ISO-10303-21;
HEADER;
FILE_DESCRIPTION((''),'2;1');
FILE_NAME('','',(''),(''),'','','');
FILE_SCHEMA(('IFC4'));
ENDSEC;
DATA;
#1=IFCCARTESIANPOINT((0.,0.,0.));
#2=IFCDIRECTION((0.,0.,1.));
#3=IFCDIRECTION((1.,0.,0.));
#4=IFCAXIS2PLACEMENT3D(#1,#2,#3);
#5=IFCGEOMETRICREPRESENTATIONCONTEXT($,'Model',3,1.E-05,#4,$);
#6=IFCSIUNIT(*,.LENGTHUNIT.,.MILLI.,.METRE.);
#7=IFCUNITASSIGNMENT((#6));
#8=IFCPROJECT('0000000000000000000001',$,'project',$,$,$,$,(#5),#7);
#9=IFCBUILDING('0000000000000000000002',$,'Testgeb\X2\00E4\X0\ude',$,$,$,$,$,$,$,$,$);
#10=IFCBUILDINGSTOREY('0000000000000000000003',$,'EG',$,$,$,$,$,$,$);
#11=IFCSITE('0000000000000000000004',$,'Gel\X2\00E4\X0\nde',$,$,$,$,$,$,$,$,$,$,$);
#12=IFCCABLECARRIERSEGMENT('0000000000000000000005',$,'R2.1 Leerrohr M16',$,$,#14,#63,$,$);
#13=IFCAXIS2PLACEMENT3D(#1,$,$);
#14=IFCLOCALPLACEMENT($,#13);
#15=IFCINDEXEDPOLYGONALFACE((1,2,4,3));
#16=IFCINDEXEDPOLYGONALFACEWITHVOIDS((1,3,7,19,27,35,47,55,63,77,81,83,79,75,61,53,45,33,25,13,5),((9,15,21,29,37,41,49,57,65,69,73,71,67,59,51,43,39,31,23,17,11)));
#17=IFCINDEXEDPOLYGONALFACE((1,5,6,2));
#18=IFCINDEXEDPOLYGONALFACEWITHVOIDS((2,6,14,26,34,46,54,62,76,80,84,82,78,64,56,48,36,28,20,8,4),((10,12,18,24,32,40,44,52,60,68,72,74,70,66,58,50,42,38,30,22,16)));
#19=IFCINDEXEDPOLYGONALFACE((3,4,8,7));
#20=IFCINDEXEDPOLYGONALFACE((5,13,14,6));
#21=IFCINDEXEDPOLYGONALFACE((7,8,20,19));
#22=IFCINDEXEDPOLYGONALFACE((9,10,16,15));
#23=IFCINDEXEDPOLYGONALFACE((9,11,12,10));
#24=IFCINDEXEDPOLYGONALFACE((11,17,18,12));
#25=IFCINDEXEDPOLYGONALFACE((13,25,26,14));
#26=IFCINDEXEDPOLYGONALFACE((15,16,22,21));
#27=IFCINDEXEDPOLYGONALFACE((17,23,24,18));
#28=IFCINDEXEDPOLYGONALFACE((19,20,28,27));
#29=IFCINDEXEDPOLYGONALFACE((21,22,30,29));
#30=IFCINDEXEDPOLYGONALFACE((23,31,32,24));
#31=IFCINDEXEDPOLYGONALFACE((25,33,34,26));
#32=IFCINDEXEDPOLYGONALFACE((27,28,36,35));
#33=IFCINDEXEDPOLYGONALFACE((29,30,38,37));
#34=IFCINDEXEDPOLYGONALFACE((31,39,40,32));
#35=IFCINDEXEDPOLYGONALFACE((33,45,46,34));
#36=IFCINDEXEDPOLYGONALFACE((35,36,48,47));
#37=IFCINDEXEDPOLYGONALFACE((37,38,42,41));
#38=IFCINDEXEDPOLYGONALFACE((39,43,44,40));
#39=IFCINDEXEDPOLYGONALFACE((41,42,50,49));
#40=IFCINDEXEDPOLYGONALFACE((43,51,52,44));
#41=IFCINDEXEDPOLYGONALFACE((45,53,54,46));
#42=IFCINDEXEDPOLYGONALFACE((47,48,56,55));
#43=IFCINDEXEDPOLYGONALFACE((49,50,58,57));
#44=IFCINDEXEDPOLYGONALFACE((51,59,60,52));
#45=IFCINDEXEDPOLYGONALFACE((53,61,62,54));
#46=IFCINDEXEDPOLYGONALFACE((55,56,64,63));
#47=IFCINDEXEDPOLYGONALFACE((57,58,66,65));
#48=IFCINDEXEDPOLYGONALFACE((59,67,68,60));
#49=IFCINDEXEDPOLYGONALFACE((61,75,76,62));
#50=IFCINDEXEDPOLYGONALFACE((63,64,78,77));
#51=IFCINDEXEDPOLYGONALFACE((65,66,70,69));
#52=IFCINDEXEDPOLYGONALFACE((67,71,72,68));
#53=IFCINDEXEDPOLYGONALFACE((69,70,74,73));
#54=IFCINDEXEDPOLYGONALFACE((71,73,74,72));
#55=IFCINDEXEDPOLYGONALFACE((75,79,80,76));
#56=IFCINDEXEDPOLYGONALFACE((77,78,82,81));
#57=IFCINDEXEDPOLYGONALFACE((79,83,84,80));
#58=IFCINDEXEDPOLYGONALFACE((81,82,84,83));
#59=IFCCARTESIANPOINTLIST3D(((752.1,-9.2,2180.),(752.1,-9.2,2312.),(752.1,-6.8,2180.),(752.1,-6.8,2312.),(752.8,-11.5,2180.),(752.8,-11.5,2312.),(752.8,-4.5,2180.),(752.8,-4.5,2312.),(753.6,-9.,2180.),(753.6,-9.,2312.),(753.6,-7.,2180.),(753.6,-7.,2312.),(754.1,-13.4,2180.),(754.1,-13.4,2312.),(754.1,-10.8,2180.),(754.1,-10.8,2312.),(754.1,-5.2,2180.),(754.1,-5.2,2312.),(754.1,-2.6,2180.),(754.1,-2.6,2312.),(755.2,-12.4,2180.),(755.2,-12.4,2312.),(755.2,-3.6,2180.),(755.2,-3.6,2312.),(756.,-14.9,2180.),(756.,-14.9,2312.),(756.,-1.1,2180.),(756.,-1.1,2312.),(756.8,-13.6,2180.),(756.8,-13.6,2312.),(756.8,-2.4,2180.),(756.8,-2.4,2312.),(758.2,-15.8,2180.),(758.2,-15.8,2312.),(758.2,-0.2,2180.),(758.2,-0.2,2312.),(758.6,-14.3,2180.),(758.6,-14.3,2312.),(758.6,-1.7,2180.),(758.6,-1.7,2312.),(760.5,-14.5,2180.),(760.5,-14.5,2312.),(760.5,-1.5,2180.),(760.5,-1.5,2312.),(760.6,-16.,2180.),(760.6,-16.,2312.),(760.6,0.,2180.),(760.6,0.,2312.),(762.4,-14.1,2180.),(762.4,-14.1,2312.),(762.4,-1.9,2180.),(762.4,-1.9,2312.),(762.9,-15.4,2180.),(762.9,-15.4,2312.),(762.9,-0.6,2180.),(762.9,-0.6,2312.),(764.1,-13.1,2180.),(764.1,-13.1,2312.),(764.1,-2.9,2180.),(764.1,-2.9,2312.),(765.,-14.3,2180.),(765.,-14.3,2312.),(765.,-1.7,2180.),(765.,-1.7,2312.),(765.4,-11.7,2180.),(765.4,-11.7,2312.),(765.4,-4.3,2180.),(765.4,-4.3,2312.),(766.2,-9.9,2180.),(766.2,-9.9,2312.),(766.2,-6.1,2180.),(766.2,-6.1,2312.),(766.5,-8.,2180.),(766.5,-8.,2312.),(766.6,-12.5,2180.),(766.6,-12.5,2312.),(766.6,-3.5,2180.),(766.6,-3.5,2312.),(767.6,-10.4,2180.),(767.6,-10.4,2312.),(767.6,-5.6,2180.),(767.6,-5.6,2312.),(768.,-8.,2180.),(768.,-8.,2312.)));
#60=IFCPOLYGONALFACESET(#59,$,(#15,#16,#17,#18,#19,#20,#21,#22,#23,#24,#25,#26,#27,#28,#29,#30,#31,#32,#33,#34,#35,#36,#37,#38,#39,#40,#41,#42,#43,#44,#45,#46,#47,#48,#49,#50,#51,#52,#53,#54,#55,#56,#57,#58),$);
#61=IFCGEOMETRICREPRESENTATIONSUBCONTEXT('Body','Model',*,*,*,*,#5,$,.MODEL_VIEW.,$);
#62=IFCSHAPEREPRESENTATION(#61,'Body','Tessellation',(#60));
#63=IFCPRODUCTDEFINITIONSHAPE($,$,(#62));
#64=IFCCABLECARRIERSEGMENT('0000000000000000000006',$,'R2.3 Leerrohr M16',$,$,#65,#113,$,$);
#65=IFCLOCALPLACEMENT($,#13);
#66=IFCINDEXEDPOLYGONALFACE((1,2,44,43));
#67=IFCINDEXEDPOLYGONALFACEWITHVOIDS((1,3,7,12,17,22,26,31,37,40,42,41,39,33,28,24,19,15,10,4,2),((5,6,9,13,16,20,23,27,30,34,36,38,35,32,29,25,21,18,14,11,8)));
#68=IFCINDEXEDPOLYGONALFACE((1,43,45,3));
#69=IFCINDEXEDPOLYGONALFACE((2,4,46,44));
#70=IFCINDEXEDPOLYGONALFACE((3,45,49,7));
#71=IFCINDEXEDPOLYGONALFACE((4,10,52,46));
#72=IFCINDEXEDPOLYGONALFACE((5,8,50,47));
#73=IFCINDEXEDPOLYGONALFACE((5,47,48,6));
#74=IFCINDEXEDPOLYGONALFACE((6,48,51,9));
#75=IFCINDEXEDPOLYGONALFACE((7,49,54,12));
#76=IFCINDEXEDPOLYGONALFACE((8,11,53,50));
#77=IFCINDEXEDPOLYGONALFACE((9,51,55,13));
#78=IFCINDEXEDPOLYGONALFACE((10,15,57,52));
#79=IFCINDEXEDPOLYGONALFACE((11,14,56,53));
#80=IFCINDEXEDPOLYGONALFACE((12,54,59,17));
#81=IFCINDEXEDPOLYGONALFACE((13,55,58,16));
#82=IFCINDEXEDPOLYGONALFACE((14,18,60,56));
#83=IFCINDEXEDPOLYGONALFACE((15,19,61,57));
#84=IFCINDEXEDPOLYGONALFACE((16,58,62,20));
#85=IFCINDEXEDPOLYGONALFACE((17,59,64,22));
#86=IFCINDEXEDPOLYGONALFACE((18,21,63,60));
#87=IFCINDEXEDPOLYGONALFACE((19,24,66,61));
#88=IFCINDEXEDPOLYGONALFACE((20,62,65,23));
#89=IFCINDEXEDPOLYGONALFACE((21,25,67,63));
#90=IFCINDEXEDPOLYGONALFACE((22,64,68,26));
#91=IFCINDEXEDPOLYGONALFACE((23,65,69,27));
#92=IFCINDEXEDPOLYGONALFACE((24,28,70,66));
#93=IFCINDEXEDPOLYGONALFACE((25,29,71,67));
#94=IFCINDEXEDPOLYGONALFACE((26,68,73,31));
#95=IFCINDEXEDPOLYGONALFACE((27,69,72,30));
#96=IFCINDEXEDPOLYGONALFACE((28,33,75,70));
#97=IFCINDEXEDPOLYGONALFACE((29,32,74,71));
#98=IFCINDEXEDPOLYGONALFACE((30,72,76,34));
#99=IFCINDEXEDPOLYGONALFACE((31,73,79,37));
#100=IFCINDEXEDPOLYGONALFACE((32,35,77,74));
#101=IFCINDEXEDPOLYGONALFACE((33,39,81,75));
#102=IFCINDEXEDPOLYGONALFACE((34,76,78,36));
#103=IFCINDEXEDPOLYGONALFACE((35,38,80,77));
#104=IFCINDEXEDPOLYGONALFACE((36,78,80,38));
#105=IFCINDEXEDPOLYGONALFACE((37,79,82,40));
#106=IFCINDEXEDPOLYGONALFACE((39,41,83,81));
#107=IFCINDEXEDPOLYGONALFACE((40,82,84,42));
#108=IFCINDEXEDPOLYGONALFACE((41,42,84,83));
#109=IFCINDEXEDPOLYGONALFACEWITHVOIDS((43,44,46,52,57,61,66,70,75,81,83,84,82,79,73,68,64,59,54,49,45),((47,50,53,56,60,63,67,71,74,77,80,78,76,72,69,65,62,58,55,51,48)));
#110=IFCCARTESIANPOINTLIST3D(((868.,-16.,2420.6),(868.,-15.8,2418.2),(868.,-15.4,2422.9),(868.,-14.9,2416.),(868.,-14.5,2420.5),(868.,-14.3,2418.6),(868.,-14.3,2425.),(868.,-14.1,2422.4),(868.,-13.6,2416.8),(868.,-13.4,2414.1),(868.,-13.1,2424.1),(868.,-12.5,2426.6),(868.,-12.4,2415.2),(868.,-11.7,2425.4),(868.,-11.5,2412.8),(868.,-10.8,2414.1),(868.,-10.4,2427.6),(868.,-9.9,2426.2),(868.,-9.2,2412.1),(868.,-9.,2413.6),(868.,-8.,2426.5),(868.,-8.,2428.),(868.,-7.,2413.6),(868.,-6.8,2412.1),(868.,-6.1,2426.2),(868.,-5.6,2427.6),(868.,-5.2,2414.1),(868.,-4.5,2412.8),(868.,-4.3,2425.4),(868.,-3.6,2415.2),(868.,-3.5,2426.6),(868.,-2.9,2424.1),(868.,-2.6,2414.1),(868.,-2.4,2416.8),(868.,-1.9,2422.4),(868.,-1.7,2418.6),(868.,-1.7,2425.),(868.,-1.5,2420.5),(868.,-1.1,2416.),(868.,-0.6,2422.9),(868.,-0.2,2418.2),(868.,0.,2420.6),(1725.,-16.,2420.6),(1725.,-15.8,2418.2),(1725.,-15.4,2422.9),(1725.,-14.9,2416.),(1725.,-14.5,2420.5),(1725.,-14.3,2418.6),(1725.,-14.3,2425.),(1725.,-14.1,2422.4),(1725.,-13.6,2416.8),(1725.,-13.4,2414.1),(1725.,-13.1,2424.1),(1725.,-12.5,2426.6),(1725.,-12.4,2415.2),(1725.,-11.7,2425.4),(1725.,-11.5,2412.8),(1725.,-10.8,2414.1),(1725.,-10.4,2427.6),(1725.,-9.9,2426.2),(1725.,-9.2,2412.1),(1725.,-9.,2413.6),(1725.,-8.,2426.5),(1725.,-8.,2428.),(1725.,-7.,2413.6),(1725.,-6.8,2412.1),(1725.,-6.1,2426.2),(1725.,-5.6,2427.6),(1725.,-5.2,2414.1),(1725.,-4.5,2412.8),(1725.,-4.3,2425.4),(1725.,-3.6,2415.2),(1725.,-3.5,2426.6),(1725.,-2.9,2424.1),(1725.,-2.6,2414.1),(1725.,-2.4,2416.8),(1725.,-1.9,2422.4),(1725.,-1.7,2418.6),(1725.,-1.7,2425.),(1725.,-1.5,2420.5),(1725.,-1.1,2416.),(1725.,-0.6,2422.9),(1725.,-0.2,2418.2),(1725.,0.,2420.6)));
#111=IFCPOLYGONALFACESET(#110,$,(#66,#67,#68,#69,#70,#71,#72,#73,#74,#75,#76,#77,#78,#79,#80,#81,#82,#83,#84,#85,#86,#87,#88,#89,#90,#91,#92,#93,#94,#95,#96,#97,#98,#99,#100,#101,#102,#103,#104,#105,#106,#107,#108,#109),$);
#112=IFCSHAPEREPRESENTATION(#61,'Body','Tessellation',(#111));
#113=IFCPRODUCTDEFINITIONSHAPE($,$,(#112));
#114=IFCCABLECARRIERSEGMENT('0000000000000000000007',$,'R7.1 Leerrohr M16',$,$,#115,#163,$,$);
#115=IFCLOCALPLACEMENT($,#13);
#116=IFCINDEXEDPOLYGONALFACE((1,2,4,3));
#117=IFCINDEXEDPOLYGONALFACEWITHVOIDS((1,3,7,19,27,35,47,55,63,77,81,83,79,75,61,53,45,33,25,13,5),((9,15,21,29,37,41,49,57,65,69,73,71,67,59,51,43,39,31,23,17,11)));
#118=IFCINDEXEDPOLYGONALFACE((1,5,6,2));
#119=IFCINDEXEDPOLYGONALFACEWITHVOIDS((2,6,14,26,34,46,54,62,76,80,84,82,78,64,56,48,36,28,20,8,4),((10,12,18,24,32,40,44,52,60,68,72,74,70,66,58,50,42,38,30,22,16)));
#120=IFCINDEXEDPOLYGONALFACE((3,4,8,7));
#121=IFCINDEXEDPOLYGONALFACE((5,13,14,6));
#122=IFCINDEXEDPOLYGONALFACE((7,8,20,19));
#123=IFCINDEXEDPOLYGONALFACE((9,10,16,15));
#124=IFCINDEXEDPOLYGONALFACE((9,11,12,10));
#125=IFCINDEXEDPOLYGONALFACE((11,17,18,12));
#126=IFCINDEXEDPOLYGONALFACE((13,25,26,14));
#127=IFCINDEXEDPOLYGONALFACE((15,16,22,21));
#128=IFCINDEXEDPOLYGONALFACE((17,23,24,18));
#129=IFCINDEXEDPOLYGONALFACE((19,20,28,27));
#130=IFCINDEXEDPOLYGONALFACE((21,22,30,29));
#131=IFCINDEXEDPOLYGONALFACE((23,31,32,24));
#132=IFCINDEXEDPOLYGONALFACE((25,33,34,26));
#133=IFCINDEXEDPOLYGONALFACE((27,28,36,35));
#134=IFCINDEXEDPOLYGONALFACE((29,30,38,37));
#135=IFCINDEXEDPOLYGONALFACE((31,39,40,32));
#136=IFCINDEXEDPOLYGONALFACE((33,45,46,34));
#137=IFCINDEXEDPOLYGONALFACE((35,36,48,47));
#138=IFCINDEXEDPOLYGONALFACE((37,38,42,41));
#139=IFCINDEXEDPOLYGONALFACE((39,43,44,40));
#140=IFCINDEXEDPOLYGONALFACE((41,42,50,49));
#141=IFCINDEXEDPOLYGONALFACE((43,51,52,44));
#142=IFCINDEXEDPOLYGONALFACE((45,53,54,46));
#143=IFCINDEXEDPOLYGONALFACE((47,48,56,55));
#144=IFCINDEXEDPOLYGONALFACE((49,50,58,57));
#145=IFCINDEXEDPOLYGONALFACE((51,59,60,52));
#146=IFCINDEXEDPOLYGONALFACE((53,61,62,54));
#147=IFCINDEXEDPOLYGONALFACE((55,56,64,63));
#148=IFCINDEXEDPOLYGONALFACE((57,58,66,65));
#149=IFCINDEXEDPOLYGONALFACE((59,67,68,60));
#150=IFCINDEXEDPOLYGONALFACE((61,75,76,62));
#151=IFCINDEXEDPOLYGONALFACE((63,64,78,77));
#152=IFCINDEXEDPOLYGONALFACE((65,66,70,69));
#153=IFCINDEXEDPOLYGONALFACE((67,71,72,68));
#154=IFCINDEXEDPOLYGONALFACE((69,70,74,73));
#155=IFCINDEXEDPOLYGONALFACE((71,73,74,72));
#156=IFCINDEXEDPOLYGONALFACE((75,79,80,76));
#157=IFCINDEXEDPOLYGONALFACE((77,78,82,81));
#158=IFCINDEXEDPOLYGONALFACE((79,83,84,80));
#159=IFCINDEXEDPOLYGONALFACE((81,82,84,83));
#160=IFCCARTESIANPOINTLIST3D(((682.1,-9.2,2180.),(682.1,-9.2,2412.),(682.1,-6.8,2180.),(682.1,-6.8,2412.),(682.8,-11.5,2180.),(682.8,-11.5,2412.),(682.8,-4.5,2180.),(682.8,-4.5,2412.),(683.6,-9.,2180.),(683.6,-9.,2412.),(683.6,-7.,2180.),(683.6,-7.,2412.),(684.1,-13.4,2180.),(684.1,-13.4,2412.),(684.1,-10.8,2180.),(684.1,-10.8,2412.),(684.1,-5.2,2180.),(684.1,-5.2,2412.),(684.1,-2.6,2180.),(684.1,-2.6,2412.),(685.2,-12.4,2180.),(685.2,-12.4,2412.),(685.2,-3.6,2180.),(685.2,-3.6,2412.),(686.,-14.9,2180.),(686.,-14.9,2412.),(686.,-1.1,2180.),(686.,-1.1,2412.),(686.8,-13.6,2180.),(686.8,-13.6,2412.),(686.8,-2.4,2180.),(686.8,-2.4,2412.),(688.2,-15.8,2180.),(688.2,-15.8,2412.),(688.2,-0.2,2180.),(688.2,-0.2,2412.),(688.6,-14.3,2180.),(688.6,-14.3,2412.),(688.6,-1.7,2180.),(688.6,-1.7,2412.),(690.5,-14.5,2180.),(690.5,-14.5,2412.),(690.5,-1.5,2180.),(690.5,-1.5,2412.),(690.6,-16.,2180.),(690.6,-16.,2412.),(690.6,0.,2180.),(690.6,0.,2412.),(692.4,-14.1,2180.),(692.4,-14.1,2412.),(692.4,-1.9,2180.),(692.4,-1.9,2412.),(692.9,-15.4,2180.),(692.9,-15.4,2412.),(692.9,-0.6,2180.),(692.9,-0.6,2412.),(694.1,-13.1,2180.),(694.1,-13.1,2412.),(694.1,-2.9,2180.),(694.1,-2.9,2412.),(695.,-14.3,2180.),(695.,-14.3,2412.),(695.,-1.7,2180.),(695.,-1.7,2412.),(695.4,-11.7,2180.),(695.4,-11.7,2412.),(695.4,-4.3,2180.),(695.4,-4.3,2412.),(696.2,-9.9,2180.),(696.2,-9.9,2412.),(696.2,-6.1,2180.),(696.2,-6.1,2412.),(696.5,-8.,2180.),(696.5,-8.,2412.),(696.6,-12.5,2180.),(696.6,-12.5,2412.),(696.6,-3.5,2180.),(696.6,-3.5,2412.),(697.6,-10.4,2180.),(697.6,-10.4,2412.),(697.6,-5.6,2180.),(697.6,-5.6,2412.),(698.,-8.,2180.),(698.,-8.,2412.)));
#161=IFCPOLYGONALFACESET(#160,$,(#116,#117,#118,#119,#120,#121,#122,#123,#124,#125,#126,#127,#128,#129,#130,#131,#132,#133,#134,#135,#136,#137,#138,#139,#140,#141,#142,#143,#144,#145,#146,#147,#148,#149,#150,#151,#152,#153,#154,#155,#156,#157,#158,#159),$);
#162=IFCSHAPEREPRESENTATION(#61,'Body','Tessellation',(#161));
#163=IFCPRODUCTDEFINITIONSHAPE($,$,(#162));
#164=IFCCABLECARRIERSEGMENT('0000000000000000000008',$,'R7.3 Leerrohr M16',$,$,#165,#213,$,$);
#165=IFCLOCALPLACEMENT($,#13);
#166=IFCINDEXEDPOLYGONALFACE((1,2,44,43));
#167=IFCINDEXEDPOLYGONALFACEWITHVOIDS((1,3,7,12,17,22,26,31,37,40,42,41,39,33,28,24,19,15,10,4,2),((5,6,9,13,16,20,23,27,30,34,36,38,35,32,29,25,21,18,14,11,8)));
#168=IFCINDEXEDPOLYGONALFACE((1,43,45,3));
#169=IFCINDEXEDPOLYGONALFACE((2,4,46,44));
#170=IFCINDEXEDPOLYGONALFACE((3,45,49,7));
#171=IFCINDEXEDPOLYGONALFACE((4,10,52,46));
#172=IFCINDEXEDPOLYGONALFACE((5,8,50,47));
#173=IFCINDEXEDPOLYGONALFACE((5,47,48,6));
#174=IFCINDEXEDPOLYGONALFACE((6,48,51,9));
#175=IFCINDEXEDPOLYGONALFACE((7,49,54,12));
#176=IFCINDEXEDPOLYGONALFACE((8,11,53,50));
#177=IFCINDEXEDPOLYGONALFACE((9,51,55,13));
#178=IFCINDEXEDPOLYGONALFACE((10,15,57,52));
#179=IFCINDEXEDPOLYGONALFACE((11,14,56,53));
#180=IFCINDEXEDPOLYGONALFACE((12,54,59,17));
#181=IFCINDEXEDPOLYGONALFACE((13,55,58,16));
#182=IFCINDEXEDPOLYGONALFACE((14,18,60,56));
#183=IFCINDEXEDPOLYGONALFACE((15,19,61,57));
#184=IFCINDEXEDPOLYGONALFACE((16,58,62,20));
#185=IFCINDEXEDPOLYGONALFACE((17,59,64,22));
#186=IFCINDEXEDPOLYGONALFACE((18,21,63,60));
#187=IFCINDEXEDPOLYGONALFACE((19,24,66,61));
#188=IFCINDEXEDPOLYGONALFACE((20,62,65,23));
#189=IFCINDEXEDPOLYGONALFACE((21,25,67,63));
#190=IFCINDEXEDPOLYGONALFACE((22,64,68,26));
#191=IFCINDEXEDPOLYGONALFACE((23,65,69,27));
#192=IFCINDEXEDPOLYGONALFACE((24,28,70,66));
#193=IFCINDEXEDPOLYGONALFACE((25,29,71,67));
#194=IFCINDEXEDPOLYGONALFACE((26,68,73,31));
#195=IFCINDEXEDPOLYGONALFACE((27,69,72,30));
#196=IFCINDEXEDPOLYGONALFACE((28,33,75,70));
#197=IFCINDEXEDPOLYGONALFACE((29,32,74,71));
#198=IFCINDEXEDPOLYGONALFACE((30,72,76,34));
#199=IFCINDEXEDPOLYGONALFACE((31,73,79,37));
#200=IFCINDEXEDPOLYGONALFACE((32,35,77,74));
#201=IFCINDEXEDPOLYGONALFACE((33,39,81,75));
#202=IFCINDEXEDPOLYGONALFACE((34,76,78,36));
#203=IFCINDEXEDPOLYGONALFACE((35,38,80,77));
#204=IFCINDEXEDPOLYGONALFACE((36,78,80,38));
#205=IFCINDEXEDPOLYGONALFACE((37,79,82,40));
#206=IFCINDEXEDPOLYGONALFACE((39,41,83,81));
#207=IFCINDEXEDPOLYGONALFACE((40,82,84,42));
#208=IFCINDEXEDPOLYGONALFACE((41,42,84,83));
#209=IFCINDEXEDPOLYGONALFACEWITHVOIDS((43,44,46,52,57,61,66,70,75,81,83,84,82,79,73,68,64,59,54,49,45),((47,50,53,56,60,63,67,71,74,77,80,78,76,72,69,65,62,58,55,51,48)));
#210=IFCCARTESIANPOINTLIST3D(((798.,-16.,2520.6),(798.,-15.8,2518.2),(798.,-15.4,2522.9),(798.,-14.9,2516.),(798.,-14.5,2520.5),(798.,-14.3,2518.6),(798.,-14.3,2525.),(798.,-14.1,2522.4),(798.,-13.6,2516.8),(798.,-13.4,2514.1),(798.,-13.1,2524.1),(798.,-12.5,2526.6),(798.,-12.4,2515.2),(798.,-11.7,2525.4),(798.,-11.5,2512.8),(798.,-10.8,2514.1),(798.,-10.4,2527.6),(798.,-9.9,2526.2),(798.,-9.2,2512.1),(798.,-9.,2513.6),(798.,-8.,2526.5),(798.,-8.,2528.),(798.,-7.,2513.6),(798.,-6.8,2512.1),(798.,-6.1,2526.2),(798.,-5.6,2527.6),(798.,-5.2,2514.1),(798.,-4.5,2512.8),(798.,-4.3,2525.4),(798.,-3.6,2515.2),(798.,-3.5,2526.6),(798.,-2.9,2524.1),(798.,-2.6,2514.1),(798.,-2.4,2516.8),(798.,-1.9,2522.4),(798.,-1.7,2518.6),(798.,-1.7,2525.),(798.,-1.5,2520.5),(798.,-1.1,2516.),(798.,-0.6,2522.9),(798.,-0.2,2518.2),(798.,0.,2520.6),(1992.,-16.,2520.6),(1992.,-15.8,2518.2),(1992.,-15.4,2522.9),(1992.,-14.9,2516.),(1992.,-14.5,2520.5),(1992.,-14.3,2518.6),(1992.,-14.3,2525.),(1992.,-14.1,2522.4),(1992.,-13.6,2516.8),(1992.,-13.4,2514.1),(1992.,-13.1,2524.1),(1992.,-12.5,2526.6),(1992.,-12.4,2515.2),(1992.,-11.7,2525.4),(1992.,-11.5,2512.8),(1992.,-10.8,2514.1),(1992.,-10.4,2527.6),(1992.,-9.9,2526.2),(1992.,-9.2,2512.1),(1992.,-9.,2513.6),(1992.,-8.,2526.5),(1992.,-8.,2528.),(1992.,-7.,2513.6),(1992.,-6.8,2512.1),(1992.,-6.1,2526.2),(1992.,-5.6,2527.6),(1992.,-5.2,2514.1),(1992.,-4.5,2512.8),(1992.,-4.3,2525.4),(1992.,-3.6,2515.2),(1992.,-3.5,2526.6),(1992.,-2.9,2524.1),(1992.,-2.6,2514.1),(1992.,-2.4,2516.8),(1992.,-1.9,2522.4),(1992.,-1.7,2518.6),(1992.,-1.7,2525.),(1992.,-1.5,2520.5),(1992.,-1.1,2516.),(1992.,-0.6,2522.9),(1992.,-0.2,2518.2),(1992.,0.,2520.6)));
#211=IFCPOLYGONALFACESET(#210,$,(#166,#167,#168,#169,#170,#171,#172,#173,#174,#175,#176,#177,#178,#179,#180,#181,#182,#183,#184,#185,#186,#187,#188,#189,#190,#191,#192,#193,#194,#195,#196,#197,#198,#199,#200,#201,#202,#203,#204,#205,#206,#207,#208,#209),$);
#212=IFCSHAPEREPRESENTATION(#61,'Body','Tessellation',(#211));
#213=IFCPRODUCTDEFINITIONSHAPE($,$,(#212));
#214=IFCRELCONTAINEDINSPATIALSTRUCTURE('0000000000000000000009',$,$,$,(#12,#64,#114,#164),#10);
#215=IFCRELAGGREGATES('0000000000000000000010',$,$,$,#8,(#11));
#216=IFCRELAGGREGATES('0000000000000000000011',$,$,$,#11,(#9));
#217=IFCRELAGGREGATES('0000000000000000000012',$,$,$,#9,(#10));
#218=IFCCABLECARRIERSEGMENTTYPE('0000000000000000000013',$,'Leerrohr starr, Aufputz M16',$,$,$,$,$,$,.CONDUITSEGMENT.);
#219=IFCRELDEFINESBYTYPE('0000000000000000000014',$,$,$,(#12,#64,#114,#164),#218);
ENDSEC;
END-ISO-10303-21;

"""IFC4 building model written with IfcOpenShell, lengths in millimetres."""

from ifc_helpers import new_model, si_unit, frame, origin_with_axes, place, context, subcontext, project, spatial, hollow_circle, extrude, type_object, element, save


model = new_model("IFC4")

# Units and contexts
model_context = context("Model", 3, precision=1e-05, world=origin_with_axes())
body_context = subcontext(model_context, "Body", "Model", "MODEL_VIEW")
ifc_project = project(units=[si_unit("LENGTHUNIT", "METRE", prefix="MILLI")], contexts=[model_context])

# Site, building, storey
site = spatial("IfcSite", under=ifc_project, Name="Gelände")
building = spatial("IfcBuilding", under=site, Name="Testgebäude")
storey = spatial("IfcBuildingStorey", under=building, Name="EG")

# Cable carrier segments
cable_carrier_segment_type_1 = type_object("IfcCableCarrierSegmentType", Name="Leerrohr starr, Aufputz M16", PredefinedType="CONDUITSEGMENT")
cable_carrier_segment_1_placement = place(None, frame((760.0, -8.0, 2180.0), z_axis=(0.0, 0.0, 1.0), x_axis=(1.0, 0.0, 0.0)))
element("IfcCableCarrierSegment", 1, at=cable_carrier_segment_1_placement, inside=storey, type_object=cable_carrier_segment_type_1, Name="R2.1 Leerrohr M16", context=body_context, shape_type="SweptSolid", body=[
    extrude(hollow_circle(Radius=8.0, WallThickness=1.5), None, (0.0, 0.0, 1.0), 132.0),
])
cable_carrier_segment_2_placement = place(None, frame((868.0, -8.0, 2420.0), z_axis=(1.0, 0.0, 0.0), x_axis=(0.0, 0.0, 1.0)))
element("IfcCableCarrierSegment", 2, at=cable_carrier_segment_2_placement, inside=storey, type_object=cable_carrier_segment_type_1, Name="R2.3 Leerrohr M16", context=body_context, shape_type="SweptSolid", body=[
    extrude(hollow_circle(Radius=8.0, WallThickness=1.5), None, (0.0, 0.0, 1.0), 857.0),
])
cable_carrier_segment_3_placement = place(None, frame((690.0, -8.0, 2180.0), z_axis=(0.0, 0.0, 1.0), x_axis=(1.0, 0.0, 0.0)))
element("IfcCableCarrierSegment", 3, at=cable_carrier_segment_3_placement, inside=storey, type_object=cable_carrier_segment_type_1, Name="R7.1 Leerrohr M16", context=body_context, shape_type="SweptSolid", body=[
    extrude(hollow_circle(Radius=8.0, WallThickness=1.5), None, (0.0, 0.0, 1.0), 232.0),
])
cable_carrier_segment_4_placement = place(None, frame((798.0, -8.0, 2520.0), z_axis=(1.0, 0.0, 0.0), x_axis=(0.0, 0.0, 1.0)))
element("IfcCableCarrierSegment", 4, at=cable_carrier_segment_4_placement, inside=storey, type_object=cable_carrier_segment_type_1, Name="R7.3 Leerrohr M16", context=body_context, shape_type="SweptSolid", body=[
    extrude(hollow_circle(Radius=8.0, WallThickness=1.5), None, (0.0, 0.0, 1.0), 1194.0),
])

save(model, "model.ifc")
